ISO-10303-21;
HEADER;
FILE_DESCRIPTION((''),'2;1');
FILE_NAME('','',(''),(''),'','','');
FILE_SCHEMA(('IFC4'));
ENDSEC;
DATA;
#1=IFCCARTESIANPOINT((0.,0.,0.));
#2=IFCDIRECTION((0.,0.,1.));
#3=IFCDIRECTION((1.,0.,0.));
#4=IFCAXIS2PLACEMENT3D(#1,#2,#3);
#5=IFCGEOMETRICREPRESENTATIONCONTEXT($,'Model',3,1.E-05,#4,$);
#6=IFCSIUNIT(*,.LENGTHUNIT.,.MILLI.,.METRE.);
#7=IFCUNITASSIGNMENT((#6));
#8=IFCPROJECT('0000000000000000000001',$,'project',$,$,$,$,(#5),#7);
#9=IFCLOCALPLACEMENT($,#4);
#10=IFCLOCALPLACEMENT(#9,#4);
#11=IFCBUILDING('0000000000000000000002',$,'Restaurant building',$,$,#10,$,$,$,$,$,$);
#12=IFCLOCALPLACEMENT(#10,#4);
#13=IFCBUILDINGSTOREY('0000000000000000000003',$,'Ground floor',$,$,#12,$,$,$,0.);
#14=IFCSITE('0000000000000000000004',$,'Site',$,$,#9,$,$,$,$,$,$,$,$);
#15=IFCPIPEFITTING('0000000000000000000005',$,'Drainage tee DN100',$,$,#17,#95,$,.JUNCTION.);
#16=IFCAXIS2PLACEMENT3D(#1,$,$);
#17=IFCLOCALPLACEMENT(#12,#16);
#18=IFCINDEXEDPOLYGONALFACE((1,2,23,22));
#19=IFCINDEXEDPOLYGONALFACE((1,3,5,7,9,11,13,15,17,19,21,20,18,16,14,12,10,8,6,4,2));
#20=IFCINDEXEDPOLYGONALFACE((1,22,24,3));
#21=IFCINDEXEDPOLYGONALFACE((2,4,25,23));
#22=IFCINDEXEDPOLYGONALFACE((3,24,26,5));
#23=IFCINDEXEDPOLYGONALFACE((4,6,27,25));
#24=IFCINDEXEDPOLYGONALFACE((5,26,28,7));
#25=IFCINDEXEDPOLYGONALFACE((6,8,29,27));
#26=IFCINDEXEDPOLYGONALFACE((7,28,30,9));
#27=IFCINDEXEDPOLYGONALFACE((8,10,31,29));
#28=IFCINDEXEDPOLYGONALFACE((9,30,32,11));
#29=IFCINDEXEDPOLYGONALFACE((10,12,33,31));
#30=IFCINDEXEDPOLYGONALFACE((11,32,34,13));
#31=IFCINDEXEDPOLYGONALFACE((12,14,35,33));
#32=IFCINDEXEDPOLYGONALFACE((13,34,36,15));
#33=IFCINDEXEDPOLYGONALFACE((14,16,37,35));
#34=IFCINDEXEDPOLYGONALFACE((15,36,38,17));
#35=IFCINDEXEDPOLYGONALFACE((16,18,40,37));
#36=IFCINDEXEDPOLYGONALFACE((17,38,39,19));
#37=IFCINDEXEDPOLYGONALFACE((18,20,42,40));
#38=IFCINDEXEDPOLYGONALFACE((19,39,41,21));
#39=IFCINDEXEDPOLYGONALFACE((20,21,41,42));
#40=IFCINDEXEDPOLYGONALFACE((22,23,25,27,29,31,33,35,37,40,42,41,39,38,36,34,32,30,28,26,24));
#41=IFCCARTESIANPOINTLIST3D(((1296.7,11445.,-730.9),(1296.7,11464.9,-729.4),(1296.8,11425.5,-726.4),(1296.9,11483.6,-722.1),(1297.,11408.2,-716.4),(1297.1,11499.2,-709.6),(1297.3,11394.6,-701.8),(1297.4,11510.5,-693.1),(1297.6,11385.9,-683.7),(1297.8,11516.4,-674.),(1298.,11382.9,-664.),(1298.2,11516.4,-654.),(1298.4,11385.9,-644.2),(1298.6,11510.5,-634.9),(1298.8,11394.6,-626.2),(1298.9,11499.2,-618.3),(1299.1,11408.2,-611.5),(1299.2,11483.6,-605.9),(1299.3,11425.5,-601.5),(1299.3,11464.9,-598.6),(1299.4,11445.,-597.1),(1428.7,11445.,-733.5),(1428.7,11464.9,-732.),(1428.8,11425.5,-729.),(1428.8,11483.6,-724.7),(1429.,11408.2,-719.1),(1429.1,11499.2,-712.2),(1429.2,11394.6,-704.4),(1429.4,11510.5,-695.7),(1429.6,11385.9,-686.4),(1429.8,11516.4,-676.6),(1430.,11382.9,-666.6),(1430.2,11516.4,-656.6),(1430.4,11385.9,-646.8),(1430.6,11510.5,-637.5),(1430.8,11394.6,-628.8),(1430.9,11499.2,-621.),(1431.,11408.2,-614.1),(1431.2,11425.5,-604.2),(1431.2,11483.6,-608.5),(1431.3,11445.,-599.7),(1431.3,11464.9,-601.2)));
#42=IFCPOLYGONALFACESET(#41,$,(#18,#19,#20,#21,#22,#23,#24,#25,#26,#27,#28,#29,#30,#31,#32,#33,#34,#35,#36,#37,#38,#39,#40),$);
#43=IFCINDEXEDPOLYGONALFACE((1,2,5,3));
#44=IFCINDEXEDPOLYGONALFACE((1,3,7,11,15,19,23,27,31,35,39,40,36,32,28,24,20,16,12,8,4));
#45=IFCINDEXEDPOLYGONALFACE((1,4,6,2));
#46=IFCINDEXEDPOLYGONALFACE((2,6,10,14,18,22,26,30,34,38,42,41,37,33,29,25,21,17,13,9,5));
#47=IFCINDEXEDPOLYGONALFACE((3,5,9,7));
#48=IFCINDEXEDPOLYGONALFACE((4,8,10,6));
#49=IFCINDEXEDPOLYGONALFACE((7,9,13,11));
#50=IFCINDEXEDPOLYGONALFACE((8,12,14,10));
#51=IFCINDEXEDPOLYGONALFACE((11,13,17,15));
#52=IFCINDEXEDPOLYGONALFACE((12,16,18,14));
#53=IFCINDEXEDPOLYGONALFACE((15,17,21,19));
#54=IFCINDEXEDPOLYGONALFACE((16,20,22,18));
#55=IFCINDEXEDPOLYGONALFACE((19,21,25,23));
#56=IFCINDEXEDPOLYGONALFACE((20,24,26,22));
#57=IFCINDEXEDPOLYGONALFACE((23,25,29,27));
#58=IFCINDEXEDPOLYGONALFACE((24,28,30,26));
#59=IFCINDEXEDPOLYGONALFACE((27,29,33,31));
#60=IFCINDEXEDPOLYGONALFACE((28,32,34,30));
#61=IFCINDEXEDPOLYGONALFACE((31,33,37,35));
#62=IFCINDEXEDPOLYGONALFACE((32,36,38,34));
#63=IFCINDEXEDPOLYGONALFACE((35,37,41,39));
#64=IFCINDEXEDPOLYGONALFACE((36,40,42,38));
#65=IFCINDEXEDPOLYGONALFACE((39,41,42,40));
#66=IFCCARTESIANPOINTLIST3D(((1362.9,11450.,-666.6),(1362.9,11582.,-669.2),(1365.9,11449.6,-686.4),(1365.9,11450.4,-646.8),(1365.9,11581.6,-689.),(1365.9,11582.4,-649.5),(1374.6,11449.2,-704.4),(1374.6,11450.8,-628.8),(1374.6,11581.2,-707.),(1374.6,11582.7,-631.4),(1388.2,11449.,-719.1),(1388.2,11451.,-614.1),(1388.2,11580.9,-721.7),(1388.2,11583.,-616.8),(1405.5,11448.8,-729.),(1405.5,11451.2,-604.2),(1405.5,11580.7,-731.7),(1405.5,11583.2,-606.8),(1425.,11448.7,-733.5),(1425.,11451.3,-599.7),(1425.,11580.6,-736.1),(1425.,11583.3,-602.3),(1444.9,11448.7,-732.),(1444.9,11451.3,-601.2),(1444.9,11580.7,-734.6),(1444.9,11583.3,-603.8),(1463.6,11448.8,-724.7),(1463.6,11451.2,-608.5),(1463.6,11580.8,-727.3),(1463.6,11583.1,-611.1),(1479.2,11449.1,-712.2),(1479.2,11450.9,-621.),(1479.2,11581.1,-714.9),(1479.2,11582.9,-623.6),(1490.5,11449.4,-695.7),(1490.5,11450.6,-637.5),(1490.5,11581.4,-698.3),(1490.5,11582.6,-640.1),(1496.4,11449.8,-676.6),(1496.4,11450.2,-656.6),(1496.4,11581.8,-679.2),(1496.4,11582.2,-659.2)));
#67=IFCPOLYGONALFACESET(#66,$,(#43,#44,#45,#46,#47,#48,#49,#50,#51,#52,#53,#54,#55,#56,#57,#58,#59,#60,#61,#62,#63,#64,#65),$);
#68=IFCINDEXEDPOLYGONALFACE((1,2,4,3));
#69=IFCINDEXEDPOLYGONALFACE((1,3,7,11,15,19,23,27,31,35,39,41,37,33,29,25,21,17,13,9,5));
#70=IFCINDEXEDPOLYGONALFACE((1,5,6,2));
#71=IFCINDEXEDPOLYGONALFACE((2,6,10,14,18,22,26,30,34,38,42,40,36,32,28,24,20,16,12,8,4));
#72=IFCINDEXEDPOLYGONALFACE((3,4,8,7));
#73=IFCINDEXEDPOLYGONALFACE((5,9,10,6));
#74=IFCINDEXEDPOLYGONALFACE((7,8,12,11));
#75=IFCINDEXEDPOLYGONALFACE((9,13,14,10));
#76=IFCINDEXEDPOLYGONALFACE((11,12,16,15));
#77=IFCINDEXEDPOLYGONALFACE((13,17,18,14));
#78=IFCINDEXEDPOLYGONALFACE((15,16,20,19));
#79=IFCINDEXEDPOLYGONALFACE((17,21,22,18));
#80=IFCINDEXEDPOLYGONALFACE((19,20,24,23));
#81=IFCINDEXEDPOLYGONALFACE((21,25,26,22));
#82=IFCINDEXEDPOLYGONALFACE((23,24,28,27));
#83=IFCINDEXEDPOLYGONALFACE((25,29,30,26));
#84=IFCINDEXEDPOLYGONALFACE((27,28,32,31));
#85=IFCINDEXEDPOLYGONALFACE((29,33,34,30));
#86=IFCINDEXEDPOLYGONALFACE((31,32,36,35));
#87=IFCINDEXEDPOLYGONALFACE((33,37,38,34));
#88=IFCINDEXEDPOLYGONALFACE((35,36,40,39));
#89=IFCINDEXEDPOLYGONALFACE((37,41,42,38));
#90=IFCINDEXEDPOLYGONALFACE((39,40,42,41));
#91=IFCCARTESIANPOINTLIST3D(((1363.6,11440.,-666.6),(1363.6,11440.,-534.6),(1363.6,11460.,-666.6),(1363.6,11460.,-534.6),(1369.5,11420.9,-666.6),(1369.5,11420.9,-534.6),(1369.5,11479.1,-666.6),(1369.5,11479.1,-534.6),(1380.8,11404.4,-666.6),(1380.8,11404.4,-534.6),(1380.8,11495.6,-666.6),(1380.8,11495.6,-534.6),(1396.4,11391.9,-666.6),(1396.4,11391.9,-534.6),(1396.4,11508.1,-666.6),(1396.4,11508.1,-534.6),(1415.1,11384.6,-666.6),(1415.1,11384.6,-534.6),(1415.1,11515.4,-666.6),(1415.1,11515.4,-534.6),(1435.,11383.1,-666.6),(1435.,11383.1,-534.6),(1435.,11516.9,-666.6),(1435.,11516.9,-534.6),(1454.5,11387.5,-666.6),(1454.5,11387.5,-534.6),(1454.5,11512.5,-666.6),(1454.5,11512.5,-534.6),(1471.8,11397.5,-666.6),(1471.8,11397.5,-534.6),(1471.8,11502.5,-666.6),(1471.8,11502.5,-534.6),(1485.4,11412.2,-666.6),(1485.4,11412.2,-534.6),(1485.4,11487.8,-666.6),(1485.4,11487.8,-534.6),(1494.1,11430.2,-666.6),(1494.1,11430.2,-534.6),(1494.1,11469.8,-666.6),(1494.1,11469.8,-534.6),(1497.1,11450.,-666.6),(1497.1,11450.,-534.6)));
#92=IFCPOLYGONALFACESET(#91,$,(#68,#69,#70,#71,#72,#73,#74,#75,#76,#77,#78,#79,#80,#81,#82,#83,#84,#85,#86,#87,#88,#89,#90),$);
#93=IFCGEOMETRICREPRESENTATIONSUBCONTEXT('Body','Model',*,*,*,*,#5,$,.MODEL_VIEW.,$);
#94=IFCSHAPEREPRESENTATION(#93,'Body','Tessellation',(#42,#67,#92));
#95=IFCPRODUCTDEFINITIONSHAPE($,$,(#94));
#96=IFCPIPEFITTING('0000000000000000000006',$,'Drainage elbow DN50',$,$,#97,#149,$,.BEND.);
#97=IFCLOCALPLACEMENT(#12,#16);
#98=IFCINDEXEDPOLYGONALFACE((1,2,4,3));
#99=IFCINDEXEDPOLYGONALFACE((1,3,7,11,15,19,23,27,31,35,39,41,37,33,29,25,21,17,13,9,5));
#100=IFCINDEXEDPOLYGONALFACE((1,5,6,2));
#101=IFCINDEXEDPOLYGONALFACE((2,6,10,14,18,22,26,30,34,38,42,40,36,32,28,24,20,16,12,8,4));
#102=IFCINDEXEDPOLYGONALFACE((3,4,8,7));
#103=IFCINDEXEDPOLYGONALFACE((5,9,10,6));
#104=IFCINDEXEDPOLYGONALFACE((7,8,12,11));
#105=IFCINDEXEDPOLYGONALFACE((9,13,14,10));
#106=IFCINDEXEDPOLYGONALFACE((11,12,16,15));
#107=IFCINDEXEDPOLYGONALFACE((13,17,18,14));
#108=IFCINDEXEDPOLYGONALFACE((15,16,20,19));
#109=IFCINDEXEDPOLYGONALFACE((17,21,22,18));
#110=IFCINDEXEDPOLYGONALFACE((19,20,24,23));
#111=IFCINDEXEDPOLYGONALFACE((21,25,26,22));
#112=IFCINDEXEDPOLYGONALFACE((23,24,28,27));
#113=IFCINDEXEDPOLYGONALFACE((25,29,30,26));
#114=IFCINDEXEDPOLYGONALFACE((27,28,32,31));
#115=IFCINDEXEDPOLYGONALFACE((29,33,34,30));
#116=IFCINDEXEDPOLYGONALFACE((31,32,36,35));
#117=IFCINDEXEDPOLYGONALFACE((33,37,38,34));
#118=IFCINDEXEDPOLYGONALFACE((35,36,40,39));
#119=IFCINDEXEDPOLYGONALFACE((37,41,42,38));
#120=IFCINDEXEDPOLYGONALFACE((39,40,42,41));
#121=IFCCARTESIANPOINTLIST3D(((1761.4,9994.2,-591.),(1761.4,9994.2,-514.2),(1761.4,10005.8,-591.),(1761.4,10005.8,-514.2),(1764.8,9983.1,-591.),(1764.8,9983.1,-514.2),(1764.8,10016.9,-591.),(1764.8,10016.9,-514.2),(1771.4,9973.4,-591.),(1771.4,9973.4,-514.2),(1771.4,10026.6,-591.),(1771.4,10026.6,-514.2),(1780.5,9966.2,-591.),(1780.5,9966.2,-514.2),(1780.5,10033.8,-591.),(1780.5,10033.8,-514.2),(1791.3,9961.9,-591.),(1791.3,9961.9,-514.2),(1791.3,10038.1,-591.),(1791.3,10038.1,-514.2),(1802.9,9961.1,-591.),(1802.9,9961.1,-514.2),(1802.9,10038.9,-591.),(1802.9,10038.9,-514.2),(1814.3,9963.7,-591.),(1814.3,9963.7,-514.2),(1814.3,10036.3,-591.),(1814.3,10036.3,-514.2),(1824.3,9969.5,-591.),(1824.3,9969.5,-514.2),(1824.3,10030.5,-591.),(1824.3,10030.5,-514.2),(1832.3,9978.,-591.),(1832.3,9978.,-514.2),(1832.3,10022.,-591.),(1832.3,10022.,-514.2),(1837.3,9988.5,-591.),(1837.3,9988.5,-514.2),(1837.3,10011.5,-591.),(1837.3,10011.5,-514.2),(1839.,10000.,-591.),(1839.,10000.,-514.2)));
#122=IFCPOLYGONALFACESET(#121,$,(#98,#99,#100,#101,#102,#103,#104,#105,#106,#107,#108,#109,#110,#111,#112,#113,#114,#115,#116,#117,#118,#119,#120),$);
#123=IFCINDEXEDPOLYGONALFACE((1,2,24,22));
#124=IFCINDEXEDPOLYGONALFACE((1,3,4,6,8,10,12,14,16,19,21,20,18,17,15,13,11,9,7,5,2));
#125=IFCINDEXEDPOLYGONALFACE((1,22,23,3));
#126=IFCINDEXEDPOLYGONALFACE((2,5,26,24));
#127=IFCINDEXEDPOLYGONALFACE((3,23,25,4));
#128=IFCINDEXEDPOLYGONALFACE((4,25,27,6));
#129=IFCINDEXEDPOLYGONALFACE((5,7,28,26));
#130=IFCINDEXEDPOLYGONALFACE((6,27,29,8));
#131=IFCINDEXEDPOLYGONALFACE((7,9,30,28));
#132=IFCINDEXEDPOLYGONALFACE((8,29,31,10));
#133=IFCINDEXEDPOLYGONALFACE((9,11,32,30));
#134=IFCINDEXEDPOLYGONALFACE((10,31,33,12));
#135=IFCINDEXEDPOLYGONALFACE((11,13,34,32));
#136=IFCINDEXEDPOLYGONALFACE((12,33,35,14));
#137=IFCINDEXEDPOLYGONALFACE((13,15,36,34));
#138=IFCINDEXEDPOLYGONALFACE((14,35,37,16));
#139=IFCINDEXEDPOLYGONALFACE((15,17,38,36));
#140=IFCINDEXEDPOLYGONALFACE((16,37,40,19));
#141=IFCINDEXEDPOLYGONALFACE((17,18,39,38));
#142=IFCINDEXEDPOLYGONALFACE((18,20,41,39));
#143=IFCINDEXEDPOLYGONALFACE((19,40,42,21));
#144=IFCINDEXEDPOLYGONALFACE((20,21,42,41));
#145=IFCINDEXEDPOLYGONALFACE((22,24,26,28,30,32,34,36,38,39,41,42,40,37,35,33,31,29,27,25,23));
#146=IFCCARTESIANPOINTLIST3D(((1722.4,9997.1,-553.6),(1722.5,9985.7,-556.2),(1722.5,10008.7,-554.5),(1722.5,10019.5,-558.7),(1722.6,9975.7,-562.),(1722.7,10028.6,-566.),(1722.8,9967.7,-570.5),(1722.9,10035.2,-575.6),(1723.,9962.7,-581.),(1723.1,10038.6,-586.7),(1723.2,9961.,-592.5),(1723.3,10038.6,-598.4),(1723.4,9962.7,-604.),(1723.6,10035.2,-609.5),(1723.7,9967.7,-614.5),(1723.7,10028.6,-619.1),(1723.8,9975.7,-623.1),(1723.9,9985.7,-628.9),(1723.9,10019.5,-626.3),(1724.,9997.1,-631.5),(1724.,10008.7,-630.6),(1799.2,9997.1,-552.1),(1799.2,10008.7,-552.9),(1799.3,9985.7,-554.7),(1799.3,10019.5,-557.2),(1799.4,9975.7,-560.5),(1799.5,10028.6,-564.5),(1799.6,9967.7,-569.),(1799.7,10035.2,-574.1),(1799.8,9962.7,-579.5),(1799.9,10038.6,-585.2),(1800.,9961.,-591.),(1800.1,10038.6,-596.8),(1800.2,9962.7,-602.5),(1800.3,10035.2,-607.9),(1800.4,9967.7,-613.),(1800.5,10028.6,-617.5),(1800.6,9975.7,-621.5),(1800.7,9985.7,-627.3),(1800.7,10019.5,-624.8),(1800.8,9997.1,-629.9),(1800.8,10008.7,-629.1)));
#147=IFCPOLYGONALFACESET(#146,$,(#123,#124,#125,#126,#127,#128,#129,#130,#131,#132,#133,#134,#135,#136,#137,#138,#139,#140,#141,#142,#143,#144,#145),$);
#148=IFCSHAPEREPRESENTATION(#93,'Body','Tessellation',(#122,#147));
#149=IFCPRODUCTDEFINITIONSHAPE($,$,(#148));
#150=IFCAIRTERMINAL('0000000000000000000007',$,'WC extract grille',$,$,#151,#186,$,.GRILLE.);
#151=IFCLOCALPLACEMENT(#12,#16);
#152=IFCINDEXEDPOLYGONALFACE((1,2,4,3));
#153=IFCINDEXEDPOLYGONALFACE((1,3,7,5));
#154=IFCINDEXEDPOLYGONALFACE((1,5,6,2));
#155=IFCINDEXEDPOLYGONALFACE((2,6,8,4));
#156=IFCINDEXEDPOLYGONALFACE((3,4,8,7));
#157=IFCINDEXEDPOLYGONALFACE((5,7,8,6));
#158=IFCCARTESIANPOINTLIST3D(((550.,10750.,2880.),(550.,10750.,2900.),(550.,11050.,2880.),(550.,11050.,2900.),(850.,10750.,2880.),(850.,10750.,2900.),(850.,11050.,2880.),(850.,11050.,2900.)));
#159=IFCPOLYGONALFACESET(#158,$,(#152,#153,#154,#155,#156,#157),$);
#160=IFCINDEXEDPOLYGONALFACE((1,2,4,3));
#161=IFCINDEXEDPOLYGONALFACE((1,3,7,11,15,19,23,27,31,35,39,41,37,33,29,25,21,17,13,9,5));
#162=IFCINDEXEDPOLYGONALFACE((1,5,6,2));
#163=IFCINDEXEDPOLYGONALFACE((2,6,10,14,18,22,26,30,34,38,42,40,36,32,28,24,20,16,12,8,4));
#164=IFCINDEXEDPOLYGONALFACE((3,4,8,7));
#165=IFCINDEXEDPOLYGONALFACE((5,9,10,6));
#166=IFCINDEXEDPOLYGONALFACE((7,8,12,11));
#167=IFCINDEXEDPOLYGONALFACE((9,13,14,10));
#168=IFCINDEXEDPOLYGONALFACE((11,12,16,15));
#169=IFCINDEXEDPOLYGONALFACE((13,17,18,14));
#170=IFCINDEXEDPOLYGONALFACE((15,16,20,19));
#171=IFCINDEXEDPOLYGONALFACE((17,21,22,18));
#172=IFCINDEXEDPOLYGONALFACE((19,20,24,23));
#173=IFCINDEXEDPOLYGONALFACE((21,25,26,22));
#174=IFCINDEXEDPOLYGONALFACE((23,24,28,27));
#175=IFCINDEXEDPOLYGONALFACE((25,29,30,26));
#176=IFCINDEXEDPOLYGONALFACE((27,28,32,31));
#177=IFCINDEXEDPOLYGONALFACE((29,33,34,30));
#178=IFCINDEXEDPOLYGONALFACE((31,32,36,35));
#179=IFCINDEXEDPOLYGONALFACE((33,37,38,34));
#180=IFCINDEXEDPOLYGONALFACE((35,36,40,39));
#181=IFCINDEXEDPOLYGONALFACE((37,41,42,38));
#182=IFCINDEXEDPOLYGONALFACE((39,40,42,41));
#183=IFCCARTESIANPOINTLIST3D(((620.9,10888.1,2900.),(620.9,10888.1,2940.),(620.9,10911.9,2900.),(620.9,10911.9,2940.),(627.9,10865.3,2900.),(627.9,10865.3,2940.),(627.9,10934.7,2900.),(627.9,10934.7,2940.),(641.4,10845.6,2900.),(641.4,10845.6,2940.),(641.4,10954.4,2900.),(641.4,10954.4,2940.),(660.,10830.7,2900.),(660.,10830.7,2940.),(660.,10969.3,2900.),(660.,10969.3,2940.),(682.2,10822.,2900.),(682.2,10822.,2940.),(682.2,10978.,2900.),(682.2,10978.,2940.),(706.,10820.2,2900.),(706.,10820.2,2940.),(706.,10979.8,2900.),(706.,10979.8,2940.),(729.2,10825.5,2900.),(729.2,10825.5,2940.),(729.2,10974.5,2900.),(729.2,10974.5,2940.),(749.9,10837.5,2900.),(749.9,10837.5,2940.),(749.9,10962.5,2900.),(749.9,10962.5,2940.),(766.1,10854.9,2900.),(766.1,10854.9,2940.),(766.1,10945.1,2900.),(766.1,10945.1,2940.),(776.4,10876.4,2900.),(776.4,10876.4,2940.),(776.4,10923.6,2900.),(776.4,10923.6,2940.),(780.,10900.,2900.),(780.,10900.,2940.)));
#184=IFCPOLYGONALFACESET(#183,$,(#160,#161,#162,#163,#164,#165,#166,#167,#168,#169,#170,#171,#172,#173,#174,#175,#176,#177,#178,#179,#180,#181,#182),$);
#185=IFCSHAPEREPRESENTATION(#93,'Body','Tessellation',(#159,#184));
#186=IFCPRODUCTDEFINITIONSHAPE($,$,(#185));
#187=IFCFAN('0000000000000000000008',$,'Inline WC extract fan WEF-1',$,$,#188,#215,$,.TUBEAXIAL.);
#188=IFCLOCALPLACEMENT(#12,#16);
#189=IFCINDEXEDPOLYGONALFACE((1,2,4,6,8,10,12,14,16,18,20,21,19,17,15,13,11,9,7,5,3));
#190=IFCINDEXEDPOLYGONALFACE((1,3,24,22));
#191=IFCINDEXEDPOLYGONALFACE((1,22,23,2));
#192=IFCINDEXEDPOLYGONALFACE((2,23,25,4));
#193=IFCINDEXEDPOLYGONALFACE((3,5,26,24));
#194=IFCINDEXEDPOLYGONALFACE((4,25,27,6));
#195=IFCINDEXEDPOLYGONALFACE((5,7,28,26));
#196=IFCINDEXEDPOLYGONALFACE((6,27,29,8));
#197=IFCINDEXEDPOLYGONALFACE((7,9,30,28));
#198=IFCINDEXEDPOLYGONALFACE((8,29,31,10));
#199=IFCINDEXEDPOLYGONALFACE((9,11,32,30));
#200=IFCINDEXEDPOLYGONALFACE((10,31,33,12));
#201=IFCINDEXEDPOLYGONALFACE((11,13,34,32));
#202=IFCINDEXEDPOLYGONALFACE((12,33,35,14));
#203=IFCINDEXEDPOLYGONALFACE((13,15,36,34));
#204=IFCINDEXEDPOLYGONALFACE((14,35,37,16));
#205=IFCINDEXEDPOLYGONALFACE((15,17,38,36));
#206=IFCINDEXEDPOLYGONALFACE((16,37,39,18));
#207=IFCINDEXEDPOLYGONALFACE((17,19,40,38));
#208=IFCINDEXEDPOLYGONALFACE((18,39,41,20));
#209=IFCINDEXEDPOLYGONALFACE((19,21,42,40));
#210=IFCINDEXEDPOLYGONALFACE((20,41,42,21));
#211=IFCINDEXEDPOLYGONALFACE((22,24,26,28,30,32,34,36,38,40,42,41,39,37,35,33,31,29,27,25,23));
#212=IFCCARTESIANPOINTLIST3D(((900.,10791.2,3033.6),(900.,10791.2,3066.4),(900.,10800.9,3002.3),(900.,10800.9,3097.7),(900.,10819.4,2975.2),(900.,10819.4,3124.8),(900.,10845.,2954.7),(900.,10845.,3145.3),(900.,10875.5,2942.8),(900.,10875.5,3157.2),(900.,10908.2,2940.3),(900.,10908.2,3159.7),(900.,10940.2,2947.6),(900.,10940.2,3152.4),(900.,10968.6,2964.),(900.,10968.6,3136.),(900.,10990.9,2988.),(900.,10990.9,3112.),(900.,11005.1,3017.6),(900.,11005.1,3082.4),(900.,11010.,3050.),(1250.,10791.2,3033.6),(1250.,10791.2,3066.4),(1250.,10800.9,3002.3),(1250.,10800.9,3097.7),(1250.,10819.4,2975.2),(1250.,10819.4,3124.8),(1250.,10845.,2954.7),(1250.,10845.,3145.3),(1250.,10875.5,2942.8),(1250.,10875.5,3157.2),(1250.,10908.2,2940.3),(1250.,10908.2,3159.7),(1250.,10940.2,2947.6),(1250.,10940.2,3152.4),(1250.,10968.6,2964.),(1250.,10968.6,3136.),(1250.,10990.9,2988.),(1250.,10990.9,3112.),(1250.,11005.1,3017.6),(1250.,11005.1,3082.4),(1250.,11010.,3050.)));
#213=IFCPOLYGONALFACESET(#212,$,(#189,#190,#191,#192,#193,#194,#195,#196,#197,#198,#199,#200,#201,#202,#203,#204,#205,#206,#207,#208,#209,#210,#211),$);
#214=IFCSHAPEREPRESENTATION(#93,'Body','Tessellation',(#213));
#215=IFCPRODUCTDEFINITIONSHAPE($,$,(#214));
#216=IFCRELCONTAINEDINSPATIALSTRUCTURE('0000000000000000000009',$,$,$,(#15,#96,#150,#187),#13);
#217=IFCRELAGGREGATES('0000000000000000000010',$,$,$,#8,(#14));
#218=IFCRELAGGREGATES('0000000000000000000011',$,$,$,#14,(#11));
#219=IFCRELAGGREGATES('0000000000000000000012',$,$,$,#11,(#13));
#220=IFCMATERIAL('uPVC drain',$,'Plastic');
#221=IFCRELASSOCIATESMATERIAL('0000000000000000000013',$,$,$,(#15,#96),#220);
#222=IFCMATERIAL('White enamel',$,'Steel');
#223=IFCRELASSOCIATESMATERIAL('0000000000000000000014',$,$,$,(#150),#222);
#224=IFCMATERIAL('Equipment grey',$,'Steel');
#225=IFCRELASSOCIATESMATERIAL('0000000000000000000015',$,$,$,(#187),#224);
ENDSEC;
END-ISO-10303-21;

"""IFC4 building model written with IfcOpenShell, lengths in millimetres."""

from ifc_helpers import new_model, si_unit, frame, origin, origin_with_axes, origin_2d, place, context, subcontext, project, spatial, rectangle, circle, extrude, material, element, save


model = new_model("IFC4")

# Units and contexts
model_context = context("Model", 3, precision=1e-05, world=origin_with_axes())
body_context = subcontext(model_context, "Body", "Model", "MODEL_VIEW")
ifc_project = project(units=[si_unit("LENGTHUNIT", "METRE", prefix="MILLI")], contexts=[model_context])

# Site, building, storey
site_placement = place(None, origin_with_axes())
site = spatial("IfcSite", under=ifc_project, at=site_placement, Name="Site")
building_placement = place(site_placement, origin_with_axes())
building = spatial("IfcBuilding", under=site, at=building_placement, Name="Restaurant building")
storey_placement = place(building_placement, origin_with_axes())
storey = spatial("IfcBuildingStorey", under=building, at=storey_placement, Name="Ground floor", Elevation=0.0)

# Shared definitions
ifc_material_1 = material(Name="uPVC drain", Category="Plastic")

# Pipe fittings
pipe_fitting_1_placement = place(storey_placement, frame((1430.0, 11450.0, -666.6)))
element("IfcPipeFitting", 1, at=pipe_fitting_1_placement, inside=storey, material=ifc_material_1, Name="Drainage tee DN100", PredefinedType="JUNCTION", context=body_context, shape_type="SweptSolid", body=[
    extrude(circle(Radius=67.1, at=origin_2d()), frame((0.0, 0.0, 0.0), z_axis=(-0.9998, 0.0, 0.019996), x_axis=(0.0, -1.0, 0.0)), (0.0, 0.0, 1.0), 132.0),
    extrude(circle(Radius=67.1, at=origin_2d()), frame((0.0, 0.0, 0.0), z_axis=(0.0, 0.9998, -0.019996), x_axis=(-1.0, 0.0, 0.0)), (0.0, 0.0, 1.0), 132.0),
    extrude(circle(Radius=67.1, at=origin_2d()), origin(), (0.0, 0.0, 1.0), 132.0),
])
pipe_fitting_2_placement = place(storey_placement, frame((1800.0, 10000.0, -591.0)))
element("IfcPipeFitting", 2, at=pipe_fitting_2_placement, inside=storey, material=ifc_material_1, Name="Drainage elbow DN50", PredefinedType="BEND", context=body_context, shape_type="SweptSolid", body=[
    extrude(circle(Radius=39.0, at=origin_2d()), origin(), (0.0, 0.0, 1.0), 76.8),
    extrude(circle(Radius=39.0, at=origin_2d()), frame((0.0, 0.0, 0.0), z_axis=(-0.9998, 0.0, -0.019996), x_axis=(0.0, -1.0, 0.0)), (0.0, 0.0, 1.0), 76.8),
])

# Air terminal
ifc_material_2 = material(Name="White enamel", Category="Steel")
air_terminal_placement = place(storey_placement, frame((700.0, 10900.0, 0.0)))
element("IfcAirTerminal", 3, at=air_terminal_placement, inside=storey, material=ifc_material_2, Name="WC extract grille", PredefinedType="GRILLE", context=body_context, shape_type="SweptSolid", body=[
    extrude(rectangle(XDim=300.0, YDim=300.0, at=origin_2d()), frame((0.0, 0.0, 2880.0)), (0.0, 0.0, 1.0), 20.0),
    extrude(circle(Radius=80.0, at=origin_2d()), frame((0.0, 0.0, 2900.0)), (0.0, 0.0, 1.0), 40.0),
])

# Fan
ifc_material_3 = material(Name="Equipment grey", Category="Steel")
fan_placement = place(storey_placement, frame((900.0, 10900.0, 0.0)))
element("IfcFan", 4, at=fan_placement, inside=storey, material=ifc_material_3, Name="Inline WC extract fan WEF-1", PredefinedType="TUBEAXIAL", context=body_context, shape_type="SweptSolid", body=[
    extrude(circle(Radius=110.0, at=origin_2d()), frame((0.0, 0.0, 3050.0), z_axis=(1.0, 0.0, 0.0), x_axis=(0.0, 1.0, 0.0)), (0.0, 0.0, 1.0), 350.0),
])

save(model, "model.ifc")
